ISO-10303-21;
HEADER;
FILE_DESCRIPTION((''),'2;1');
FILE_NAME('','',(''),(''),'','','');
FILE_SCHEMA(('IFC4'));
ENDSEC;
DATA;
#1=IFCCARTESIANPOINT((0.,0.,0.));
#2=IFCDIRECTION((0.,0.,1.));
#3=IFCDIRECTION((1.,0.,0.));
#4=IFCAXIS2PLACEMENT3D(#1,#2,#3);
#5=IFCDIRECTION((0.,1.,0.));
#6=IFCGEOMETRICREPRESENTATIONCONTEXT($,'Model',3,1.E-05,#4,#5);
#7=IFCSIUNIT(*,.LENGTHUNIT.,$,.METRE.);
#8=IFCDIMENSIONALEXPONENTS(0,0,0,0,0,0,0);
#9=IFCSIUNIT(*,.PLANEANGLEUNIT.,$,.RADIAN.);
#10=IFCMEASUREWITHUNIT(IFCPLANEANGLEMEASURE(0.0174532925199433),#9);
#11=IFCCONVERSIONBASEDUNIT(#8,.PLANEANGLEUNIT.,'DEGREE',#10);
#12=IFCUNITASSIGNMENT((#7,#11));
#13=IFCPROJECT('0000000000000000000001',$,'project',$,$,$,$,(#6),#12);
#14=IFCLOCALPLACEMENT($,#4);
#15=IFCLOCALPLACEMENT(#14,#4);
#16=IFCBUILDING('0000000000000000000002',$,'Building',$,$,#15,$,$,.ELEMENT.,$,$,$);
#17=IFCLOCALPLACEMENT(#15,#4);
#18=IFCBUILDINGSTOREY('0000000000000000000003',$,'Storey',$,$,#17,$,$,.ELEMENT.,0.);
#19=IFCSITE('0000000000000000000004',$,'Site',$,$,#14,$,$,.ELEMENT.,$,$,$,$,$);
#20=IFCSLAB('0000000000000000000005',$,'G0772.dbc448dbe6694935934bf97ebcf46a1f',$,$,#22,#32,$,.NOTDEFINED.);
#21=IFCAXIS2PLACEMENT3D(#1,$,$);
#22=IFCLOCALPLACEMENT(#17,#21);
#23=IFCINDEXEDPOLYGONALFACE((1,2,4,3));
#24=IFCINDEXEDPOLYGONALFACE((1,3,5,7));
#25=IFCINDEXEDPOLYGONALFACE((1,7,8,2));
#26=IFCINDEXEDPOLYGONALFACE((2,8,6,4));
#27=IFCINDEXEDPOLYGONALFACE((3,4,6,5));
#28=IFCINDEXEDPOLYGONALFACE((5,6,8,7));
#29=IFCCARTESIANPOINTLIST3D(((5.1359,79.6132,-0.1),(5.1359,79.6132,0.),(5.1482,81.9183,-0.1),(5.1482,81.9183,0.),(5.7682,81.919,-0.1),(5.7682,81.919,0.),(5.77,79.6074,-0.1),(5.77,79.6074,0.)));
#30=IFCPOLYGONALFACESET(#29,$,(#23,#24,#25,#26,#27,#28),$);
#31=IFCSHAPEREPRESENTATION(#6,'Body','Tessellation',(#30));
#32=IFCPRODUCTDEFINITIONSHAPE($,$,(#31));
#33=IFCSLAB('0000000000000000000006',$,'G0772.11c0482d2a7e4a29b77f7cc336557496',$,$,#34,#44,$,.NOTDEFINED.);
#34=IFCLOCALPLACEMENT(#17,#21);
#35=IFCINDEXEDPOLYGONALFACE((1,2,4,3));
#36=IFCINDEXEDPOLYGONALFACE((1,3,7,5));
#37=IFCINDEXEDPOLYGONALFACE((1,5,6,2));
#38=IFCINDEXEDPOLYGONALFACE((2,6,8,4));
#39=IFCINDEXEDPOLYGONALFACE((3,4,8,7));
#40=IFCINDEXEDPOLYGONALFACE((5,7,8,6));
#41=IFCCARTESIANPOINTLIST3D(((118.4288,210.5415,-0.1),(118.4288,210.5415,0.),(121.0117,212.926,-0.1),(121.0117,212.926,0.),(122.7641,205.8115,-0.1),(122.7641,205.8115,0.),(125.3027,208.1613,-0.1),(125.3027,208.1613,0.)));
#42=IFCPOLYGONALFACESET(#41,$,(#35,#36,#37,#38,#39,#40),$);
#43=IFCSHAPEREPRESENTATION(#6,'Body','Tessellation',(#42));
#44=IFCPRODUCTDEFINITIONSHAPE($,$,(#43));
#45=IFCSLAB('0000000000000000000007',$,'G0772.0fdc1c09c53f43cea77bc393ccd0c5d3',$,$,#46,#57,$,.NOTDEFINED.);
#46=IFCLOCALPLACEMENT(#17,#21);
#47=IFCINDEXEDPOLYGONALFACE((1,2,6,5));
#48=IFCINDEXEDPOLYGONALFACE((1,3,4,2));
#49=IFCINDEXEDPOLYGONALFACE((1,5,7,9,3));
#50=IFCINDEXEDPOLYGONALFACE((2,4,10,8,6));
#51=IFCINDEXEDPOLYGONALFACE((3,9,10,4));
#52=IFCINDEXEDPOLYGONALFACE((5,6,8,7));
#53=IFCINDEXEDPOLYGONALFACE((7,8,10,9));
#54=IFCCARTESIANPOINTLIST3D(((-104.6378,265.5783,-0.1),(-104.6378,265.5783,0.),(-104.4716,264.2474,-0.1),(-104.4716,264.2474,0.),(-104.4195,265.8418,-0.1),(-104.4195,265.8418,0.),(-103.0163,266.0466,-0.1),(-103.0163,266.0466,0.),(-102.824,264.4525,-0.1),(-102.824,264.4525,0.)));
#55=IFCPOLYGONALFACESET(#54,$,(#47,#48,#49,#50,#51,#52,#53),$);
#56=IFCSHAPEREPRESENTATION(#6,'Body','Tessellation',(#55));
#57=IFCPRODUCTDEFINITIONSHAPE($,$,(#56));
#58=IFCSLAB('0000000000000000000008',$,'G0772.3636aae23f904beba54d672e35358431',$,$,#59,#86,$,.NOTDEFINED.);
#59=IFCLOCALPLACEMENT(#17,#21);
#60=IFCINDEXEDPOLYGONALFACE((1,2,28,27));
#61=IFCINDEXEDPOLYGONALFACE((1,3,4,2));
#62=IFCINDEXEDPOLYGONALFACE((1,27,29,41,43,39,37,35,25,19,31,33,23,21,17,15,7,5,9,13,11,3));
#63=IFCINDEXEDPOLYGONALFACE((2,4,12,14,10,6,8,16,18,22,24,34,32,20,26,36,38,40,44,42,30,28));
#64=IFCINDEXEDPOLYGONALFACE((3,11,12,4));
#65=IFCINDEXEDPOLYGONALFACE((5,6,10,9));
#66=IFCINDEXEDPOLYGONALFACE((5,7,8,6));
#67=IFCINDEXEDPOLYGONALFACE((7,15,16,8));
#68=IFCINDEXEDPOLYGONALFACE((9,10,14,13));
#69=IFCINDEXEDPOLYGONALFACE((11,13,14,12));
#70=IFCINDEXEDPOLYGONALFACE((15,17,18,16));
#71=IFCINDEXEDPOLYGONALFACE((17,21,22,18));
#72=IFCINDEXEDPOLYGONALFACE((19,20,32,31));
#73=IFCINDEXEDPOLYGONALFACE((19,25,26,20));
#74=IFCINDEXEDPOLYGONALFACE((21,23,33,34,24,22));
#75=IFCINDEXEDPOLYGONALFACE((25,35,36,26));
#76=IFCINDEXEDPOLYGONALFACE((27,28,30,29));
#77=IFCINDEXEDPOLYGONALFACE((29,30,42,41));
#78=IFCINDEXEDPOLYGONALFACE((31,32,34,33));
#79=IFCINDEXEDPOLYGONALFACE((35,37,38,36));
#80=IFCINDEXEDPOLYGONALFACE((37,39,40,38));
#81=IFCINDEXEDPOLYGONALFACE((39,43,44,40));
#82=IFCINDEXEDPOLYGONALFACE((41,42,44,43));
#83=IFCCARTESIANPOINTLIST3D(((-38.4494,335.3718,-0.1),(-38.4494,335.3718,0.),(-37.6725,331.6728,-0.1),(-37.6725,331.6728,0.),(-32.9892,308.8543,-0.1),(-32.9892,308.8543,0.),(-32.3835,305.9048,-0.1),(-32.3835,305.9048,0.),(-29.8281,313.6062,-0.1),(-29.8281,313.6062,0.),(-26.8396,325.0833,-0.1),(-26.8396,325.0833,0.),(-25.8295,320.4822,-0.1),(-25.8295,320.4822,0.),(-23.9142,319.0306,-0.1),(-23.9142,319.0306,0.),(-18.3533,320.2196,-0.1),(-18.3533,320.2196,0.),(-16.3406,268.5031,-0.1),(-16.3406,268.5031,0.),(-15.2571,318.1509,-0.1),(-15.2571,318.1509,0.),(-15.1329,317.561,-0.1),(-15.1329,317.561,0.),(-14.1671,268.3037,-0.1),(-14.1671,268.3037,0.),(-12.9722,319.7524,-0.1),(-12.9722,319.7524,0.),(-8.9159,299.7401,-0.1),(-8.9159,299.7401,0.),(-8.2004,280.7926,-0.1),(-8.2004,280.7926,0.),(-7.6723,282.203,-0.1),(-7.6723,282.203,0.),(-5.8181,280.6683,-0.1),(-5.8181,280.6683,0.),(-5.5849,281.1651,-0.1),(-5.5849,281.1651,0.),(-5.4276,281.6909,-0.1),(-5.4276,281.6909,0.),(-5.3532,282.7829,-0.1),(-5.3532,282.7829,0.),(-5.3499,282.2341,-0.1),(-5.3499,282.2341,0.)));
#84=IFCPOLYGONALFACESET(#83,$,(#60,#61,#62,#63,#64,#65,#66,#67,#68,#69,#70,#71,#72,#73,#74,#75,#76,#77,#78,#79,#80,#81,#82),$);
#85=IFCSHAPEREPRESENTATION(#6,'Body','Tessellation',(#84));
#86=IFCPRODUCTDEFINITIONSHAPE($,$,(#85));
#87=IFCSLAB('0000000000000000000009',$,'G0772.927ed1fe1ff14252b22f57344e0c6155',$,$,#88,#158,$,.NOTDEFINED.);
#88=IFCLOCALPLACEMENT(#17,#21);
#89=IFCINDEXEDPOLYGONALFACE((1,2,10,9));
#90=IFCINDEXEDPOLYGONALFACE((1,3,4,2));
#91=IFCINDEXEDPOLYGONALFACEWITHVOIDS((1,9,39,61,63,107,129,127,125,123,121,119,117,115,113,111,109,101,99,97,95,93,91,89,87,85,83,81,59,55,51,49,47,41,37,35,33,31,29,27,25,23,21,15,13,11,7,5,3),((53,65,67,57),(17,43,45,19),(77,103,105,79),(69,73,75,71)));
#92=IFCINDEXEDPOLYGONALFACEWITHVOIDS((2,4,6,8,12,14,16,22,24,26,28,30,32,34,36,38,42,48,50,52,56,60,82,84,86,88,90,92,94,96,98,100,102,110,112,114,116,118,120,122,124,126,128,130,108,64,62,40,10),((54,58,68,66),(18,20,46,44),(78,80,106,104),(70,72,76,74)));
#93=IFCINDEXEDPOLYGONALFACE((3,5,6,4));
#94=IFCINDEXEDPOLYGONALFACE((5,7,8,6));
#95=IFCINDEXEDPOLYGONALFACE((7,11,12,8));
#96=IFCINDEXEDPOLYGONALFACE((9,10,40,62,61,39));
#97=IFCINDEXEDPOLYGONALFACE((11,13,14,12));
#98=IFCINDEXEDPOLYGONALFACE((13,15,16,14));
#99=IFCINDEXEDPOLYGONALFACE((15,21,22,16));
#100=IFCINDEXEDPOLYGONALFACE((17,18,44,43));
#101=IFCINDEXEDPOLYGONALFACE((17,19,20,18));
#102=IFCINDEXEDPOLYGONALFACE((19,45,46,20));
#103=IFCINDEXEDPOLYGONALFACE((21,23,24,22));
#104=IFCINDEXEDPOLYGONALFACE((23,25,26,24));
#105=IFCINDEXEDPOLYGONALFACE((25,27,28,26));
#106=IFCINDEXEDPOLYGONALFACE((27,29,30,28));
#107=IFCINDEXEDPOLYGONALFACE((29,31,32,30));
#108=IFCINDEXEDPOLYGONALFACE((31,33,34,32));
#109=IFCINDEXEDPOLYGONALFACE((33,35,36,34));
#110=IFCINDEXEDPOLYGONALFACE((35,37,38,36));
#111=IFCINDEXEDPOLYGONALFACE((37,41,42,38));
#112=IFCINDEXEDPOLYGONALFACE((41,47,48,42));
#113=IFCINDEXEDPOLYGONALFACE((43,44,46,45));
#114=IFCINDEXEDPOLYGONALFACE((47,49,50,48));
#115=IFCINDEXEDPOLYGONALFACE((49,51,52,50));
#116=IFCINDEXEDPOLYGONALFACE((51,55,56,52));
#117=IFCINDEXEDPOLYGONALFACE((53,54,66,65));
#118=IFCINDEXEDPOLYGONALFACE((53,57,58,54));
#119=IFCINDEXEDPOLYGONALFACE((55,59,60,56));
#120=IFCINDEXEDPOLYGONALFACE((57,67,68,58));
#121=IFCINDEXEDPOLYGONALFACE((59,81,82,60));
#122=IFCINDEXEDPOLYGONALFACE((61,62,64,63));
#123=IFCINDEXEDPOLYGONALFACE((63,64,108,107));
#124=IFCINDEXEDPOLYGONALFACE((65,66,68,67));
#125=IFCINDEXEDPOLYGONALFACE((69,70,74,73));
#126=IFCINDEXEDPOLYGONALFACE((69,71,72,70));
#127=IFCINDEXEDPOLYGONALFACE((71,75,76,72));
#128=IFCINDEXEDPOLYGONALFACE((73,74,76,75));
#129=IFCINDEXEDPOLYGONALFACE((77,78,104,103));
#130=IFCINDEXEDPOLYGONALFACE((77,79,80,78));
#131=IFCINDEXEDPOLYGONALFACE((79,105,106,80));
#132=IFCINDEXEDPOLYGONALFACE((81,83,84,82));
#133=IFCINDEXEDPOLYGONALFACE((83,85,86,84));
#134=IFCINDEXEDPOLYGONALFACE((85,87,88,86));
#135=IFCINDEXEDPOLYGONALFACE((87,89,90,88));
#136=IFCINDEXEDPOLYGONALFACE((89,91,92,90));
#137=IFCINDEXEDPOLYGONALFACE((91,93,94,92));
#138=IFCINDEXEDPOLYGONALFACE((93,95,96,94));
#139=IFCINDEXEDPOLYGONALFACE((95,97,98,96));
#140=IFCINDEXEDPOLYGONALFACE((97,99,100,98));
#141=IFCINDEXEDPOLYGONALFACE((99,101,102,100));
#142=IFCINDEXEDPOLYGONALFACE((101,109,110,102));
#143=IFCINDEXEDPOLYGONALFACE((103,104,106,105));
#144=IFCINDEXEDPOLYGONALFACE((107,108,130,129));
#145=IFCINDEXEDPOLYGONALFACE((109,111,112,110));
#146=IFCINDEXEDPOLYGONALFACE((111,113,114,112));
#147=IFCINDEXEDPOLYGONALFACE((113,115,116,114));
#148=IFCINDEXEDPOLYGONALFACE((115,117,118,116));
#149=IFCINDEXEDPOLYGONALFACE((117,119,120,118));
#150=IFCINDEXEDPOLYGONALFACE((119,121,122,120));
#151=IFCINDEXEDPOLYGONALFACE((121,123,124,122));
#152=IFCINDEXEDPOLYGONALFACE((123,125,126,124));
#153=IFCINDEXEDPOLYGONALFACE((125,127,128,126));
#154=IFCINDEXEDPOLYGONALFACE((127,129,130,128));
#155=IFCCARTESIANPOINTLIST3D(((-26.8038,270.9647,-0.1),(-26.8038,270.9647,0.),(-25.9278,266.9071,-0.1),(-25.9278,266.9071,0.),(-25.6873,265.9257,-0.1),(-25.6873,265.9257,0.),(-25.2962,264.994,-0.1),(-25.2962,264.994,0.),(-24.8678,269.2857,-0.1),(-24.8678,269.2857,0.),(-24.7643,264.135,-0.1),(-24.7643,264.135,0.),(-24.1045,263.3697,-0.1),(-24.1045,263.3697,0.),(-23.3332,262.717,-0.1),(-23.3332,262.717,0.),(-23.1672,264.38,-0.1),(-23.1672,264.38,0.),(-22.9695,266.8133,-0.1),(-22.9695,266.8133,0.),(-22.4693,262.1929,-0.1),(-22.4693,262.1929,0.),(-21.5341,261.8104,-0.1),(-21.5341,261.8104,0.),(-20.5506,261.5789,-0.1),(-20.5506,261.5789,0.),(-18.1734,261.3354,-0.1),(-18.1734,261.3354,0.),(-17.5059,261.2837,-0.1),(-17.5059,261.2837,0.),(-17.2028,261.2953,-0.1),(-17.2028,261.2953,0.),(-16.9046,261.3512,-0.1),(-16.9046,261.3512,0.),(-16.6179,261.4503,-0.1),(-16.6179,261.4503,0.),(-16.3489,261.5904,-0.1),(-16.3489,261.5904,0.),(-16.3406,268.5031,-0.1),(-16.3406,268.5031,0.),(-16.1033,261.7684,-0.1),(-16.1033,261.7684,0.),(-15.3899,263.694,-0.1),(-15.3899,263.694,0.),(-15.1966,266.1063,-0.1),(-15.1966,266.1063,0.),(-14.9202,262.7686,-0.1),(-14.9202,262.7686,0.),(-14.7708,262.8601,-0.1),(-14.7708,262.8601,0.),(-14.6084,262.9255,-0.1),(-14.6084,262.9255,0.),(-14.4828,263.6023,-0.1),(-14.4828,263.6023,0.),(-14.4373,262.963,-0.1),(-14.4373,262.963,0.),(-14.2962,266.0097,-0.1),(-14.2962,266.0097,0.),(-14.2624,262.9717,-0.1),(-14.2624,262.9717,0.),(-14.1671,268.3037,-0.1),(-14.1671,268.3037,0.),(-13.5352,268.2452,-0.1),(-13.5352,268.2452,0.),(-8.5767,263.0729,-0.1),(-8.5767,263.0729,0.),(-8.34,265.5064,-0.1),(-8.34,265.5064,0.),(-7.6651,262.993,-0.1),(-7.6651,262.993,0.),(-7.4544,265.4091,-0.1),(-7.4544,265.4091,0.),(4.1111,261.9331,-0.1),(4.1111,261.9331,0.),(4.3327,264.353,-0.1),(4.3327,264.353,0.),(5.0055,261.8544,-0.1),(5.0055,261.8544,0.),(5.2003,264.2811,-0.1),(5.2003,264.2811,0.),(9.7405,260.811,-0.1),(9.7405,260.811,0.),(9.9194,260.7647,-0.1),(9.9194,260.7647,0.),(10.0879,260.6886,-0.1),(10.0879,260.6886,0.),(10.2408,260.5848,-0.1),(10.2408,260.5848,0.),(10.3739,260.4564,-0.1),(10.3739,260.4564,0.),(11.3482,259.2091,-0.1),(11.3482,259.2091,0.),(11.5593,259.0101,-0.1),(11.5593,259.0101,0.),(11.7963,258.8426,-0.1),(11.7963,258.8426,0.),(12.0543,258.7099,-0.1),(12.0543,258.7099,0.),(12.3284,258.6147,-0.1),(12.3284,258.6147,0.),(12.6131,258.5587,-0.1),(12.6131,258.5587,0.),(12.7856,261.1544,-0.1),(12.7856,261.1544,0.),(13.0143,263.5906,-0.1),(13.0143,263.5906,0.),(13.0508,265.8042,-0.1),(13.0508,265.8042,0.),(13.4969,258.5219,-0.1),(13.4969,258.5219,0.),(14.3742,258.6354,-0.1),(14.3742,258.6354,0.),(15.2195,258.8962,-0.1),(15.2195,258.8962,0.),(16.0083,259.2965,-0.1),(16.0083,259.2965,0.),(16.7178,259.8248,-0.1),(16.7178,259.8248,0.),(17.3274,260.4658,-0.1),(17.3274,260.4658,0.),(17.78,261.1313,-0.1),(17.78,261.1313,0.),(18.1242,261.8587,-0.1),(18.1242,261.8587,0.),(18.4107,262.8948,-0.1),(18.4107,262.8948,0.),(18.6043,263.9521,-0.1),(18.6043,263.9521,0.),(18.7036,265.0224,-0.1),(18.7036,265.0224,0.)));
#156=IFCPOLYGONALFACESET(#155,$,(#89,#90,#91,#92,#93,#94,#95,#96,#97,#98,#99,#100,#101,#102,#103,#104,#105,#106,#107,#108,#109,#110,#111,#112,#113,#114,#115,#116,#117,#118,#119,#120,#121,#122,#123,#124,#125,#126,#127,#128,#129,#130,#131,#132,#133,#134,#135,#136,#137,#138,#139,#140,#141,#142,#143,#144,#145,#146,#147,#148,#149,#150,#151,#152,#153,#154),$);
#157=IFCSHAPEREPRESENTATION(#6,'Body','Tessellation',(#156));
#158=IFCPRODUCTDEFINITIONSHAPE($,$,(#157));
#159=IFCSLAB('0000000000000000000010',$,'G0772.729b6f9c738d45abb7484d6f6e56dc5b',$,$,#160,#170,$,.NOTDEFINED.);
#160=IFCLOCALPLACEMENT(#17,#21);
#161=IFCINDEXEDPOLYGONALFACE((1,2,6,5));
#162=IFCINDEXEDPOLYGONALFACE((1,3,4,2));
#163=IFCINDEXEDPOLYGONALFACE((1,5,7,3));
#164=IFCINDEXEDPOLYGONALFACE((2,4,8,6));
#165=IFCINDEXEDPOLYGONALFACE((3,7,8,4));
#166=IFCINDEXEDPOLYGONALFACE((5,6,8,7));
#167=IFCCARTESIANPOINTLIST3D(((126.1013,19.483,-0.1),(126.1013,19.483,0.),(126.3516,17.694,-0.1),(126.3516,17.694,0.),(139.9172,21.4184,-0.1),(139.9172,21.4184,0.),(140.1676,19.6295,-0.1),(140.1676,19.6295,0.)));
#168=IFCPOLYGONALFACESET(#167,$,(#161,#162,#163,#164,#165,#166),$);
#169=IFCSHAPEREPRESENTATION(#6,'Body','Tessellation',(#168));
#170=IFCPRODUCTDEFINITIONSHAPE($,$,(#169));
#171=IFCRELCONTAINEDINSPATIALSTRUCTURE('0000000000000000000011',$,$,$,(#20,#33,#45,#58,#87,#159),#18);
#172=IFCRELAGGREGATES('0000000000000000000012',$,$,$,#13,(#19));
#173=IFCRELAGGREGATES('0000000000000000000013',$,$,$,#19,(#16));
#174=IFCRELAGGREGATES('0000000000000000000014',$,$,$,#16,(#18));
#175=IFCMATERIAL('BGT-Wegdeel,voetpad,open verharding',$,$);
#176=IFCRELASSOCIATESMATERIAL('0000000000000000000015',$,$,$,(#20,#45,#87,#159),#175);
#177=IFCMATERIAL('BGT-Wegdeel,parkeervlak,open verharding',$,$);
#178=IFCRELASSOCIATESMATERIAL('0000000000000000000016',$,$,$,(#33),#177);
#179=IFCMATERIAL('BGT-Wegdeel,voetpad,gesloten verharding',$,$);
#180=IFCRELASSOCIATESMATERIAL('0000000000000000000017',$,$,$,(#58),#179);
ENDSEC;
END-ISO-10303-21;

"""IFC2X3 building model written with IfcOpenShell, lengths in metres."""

from ifc_helpers import new_model, entity, si_unit, converted_unit, direction, frame, origin_with_axes, place, context, project, spatial, polyline, outline, extrude, material, element, save


model = new_model("IFC2X3")

# Units and contexts
model_context = context("Model", 3, precision=1e-05, world=origin_with_axes(), true_north=direction((0.0, 1.0, 0.0)))
ifc_project = project(units=[si_unit("LENGTHUNIT", "METRE"), converted_unit("PLANEANGLEUNIT", "DEGREE", entity("IfcPlaneAngleMeasure", 0.0174532925199433), si_unit("PLANEANGLEUNIT", "RADIAN"), dimensions=[0, 0, 0, 0, 0, 0, 0])], contexts=[model_context])

# Site, building, storey
site_placement = place(None, origin_with_axes())
site = spatial("IfcSite", under=ifc_project, at=site_placement, Name="Site", CompositionType="ELEMENT")
building_placement = place(site_placement, origin_with_axes())
building = spatial("IfcBuilding", under=site, at=building_placement, Name="Building", CompositionType="ELEMENT")
storey_placement = place(building_placement, origin_with_axes())
storey = spatial("IfcBuildingStorey", under=building, at=storey_placement, Name="Storey", CompositionType="ELEMENT", Elevation=0.0)

# Slabs
ifc_material_1 = material(Name="BGT-Wegdeel,voetpad,open verharding")
ifc_material_2 = material(Name="BGT-Wegdeel,voetpad,gesloten verharding")
slab_1_placement = place(storey_placement, frame((0.0, 0.0, -0.1), z_axis=(0.0, 0.0, 1.0), x_axis=(1.0, 0.0, 0.0)))
element("IfcSlab", 1, at=slab_1_placement, inside=storey, material=ifc_material_1, Name="G0772.dbc448dbe6694935934bf97ebcf46a1f", PredefinedType="NOTDEFINED", context=model_context, shape_type="SweptSolid", body=[
    extrude(outline(polyline([(5.77, 79.6074), (5.1359, 79.6132), (5.1482, 81.9183), (5.7682, 81.919), (5.77, 79.6074)])), origin_with_axes(), (0.0, 0.0, 1.0), 0.1),
])
ifc_material_3 = material(Name="BGT-Wegdeel,parkeervlak,open verharding")
slab_2_placement = place(storey_placement, frame((0.0, 0.0, -0.1), z_axis=(0.0, 0.0, 1.0), x_axis=(1.0, 0.0, 0.0)))
element("IfcSlab", 2, at=slab_2_placement, inside=storey, material=ifc_material_3, Name="G0772.11c0482d2a7e4a29b77f7cc336557496", PredefinedType="NOTDEFINED", context=model_context, shape_type="SweptSolid", body=[
    extrude(outline(polyline([(125.3027, 208.1613), (122.7641, 205.8115), (118.4288, 210.5415), (121.0117, 212.926), (125.3027, 208.1613)])), origin_with_axes(), (0.0, 0.0, 1.0), 0.1),
])
slab_3_placement = place(storey_placement, frame((0.0, 0.0, -0.1), z_axis=(0.0, 0.0, 1.0), x_axis=(1.0, 0.0, 0.0)))
element("IfcSlab", 3, at=slab_3_placement, inside=storey, material=ifc_material_1, Name="G0772.0fdc1c09c53f43cea77bc393ccd0c5d3", PredefinedType="NOTDEFINED", context=model_context, shape_type="SweptSolid", body=[
    extrude(outline(polyline([(-103.0163, 266.0466), (-102.824, 264.4525), (-104.4716, 264.2474), (-104.6378, 265.5783), (-104.4195, 265.8418), (-103.0163, 266.0466)])), origin_with_axes(), (0.0, 0.0, 1.0), 0.1),
])
slab_4_placement = place(storey_placement, frame((0.0, 0.0, -0.1), z_axis=(0.0, 0.0, 1.0), x_axis=(1.0, 0.0, 0.0)))
element("IfcSlab", 4, at=slab_4_placement, inside=storey, material=ifc_material_2, Name="G0772.3636aae23f904beba54d672e35358431", PredefinedType="NOTDEFINED", context=model_context, shape_type="SweptSolid", body=[
    extrude(outline(polyline([(-12.9722, 319.7524), (-8.9159, 299.7401), (-5.3532, 282.7829), (-5.3499, 282.2341), (-5.4276, 281.6909), (-5.5849, 281.1651), (-5.8181, 280.6683), (-14.1671, 268.3037), (-16.3406, 268.5031), (-8.2004, 280.7926), (-7.6723, 282.203), (-15.1329, 317.561), (-15.2571, 318.1509), (-18.3533, 320.2196), (-23.9142, 319.0306), (-32.3835, 305.9048), (-32.9892, 308.8543), (-29.8281, 313.6062), (-25.8295, 320.4822), (-26.8396, 325.0833), (-37.6725, 331.6728), (-38.4494, 335.3718), (-12.9722, 319.7524)])), origin_with_axes(), (0.0, 0.0, 1.0), 0.1),
])
slab_5_placement = place(storey_placement, frame((0.0, 0.0, -0.1), z_axis=(0.0, 0.0, 1.0), x_axis=(1.0, 0.0, 0.0)))
element("IfcSlab", 5, at=slab_5_placement, inside=storey, material=ifc_material_1, Name="G0772.927ed1fe1ff14252b22f57344e0c6155", PredefinedType="NOTDEFINED", context=model_context, shape_type="SweptSolid", body=[
    extrude(outline(polyline([(-16.3406, 268.5031), (-14.1671, 268.3037), (-13.5352, 268.2452), (13.0508, 265.8042), (18.7036, 265.0224), (18.6043, 263.9521), (18.4107, 262.8948), (18.1242, 261.8587), (17.78, 261.1313), (17.3274, 260.4658), (16.7178, 259.8248), (16.0083, 259.2965), (15.2195, 258.8962), (14.3742, 258.6354), (13.4969, 258.5219), (12.6131, 258.5587), (12.3284, 258.6147), (12.0543, 258.7099), (11.7963, 258.8426), (11.5593, 259.0101), (11.3482, 259.2091), (10.3739, 260.4564), (10.2408, 260.5848), (10.0879, 260.6886), (9.9194, 260.7647), (9.7405, 260.811), (-14.2624, 262.9717), (-14.4373, 262.963), (-14.6084, 262.9255), (-14.7708, 262.8601), (-14.9202, 262.7686), (-16.1033, 261.7684), (-16.3489, 261.5904), (-16.6179, 261.4503), (-16.9046, 261.3512), (-17.2028, 261.2953), (-17.5059, 261.2837), (-18.1734, 261.3354), (-20.5506, 261.5789), (-21.5341, 261.8104), (-22.4693, 262.1929), (-23.3332, 262.717), (-24.1045, 263.3697), (-24.7643, 264.135), (-25.2962, 264.994), (-25.6873, 265.9257), (-25.9278, 266.9071), (-26.8038, 270.9647), (-24.8678, 269.2857), (-16.3406, 268.5031)]), holes=[polyline([(5.0055, 261.8544), (12.7856, 261.1544), (13.0143, 263.5906), (5.2003, 264.2811), (5.0055, 261.8544)]), polyline([(-7.6651, 262.993), (4.1111, 261.9331), (4.3327, 264.353), (-7.4544, 265.4091), (-7.6651, 262.993)]), polyline([(-14.4828, 263.6023), (-8.5767, 263.0729), (-8.34, 265.5064), (-14.2962, 266.0097), (-14.4828, 263.6023)]), polyline([(-23.1672, 264.38), (-15.3899, 263.694), (-15.1966, 266.1063), (-22.9695, 266.8133), (-23.1672, 264.38)])]), origin_with_axes(), (0.0, 0.0, 1.0), 0.1),
])
slab_6_placement = place(storey_placement, frame((0.0, 0.0, -0.1), z_axis=(0.0, 0.0, 1.0), x_axis=(1.0, 0.0, 0.0)))
element("IfcSlab", 6, at=slab_6_placement, inside=storey, material=ifc_material_1, Name="G0772.729b6f9c738d45abb7484d6f6e56dc5b", PredefinedType="NOTDEFINED", context=model_context, shape_type="SweptSolid", body=[
    extrude(outline(polyline([(140.1676, 19.6295), (126.3516, 17.694), (126.1013, 19.483), (139.9172, 21.4184), (140.1676, 19.6295)])), origin_with_axes(), (0.0, 0.0, 1.0), 0.1),
])

save(model, "model.ifc")
